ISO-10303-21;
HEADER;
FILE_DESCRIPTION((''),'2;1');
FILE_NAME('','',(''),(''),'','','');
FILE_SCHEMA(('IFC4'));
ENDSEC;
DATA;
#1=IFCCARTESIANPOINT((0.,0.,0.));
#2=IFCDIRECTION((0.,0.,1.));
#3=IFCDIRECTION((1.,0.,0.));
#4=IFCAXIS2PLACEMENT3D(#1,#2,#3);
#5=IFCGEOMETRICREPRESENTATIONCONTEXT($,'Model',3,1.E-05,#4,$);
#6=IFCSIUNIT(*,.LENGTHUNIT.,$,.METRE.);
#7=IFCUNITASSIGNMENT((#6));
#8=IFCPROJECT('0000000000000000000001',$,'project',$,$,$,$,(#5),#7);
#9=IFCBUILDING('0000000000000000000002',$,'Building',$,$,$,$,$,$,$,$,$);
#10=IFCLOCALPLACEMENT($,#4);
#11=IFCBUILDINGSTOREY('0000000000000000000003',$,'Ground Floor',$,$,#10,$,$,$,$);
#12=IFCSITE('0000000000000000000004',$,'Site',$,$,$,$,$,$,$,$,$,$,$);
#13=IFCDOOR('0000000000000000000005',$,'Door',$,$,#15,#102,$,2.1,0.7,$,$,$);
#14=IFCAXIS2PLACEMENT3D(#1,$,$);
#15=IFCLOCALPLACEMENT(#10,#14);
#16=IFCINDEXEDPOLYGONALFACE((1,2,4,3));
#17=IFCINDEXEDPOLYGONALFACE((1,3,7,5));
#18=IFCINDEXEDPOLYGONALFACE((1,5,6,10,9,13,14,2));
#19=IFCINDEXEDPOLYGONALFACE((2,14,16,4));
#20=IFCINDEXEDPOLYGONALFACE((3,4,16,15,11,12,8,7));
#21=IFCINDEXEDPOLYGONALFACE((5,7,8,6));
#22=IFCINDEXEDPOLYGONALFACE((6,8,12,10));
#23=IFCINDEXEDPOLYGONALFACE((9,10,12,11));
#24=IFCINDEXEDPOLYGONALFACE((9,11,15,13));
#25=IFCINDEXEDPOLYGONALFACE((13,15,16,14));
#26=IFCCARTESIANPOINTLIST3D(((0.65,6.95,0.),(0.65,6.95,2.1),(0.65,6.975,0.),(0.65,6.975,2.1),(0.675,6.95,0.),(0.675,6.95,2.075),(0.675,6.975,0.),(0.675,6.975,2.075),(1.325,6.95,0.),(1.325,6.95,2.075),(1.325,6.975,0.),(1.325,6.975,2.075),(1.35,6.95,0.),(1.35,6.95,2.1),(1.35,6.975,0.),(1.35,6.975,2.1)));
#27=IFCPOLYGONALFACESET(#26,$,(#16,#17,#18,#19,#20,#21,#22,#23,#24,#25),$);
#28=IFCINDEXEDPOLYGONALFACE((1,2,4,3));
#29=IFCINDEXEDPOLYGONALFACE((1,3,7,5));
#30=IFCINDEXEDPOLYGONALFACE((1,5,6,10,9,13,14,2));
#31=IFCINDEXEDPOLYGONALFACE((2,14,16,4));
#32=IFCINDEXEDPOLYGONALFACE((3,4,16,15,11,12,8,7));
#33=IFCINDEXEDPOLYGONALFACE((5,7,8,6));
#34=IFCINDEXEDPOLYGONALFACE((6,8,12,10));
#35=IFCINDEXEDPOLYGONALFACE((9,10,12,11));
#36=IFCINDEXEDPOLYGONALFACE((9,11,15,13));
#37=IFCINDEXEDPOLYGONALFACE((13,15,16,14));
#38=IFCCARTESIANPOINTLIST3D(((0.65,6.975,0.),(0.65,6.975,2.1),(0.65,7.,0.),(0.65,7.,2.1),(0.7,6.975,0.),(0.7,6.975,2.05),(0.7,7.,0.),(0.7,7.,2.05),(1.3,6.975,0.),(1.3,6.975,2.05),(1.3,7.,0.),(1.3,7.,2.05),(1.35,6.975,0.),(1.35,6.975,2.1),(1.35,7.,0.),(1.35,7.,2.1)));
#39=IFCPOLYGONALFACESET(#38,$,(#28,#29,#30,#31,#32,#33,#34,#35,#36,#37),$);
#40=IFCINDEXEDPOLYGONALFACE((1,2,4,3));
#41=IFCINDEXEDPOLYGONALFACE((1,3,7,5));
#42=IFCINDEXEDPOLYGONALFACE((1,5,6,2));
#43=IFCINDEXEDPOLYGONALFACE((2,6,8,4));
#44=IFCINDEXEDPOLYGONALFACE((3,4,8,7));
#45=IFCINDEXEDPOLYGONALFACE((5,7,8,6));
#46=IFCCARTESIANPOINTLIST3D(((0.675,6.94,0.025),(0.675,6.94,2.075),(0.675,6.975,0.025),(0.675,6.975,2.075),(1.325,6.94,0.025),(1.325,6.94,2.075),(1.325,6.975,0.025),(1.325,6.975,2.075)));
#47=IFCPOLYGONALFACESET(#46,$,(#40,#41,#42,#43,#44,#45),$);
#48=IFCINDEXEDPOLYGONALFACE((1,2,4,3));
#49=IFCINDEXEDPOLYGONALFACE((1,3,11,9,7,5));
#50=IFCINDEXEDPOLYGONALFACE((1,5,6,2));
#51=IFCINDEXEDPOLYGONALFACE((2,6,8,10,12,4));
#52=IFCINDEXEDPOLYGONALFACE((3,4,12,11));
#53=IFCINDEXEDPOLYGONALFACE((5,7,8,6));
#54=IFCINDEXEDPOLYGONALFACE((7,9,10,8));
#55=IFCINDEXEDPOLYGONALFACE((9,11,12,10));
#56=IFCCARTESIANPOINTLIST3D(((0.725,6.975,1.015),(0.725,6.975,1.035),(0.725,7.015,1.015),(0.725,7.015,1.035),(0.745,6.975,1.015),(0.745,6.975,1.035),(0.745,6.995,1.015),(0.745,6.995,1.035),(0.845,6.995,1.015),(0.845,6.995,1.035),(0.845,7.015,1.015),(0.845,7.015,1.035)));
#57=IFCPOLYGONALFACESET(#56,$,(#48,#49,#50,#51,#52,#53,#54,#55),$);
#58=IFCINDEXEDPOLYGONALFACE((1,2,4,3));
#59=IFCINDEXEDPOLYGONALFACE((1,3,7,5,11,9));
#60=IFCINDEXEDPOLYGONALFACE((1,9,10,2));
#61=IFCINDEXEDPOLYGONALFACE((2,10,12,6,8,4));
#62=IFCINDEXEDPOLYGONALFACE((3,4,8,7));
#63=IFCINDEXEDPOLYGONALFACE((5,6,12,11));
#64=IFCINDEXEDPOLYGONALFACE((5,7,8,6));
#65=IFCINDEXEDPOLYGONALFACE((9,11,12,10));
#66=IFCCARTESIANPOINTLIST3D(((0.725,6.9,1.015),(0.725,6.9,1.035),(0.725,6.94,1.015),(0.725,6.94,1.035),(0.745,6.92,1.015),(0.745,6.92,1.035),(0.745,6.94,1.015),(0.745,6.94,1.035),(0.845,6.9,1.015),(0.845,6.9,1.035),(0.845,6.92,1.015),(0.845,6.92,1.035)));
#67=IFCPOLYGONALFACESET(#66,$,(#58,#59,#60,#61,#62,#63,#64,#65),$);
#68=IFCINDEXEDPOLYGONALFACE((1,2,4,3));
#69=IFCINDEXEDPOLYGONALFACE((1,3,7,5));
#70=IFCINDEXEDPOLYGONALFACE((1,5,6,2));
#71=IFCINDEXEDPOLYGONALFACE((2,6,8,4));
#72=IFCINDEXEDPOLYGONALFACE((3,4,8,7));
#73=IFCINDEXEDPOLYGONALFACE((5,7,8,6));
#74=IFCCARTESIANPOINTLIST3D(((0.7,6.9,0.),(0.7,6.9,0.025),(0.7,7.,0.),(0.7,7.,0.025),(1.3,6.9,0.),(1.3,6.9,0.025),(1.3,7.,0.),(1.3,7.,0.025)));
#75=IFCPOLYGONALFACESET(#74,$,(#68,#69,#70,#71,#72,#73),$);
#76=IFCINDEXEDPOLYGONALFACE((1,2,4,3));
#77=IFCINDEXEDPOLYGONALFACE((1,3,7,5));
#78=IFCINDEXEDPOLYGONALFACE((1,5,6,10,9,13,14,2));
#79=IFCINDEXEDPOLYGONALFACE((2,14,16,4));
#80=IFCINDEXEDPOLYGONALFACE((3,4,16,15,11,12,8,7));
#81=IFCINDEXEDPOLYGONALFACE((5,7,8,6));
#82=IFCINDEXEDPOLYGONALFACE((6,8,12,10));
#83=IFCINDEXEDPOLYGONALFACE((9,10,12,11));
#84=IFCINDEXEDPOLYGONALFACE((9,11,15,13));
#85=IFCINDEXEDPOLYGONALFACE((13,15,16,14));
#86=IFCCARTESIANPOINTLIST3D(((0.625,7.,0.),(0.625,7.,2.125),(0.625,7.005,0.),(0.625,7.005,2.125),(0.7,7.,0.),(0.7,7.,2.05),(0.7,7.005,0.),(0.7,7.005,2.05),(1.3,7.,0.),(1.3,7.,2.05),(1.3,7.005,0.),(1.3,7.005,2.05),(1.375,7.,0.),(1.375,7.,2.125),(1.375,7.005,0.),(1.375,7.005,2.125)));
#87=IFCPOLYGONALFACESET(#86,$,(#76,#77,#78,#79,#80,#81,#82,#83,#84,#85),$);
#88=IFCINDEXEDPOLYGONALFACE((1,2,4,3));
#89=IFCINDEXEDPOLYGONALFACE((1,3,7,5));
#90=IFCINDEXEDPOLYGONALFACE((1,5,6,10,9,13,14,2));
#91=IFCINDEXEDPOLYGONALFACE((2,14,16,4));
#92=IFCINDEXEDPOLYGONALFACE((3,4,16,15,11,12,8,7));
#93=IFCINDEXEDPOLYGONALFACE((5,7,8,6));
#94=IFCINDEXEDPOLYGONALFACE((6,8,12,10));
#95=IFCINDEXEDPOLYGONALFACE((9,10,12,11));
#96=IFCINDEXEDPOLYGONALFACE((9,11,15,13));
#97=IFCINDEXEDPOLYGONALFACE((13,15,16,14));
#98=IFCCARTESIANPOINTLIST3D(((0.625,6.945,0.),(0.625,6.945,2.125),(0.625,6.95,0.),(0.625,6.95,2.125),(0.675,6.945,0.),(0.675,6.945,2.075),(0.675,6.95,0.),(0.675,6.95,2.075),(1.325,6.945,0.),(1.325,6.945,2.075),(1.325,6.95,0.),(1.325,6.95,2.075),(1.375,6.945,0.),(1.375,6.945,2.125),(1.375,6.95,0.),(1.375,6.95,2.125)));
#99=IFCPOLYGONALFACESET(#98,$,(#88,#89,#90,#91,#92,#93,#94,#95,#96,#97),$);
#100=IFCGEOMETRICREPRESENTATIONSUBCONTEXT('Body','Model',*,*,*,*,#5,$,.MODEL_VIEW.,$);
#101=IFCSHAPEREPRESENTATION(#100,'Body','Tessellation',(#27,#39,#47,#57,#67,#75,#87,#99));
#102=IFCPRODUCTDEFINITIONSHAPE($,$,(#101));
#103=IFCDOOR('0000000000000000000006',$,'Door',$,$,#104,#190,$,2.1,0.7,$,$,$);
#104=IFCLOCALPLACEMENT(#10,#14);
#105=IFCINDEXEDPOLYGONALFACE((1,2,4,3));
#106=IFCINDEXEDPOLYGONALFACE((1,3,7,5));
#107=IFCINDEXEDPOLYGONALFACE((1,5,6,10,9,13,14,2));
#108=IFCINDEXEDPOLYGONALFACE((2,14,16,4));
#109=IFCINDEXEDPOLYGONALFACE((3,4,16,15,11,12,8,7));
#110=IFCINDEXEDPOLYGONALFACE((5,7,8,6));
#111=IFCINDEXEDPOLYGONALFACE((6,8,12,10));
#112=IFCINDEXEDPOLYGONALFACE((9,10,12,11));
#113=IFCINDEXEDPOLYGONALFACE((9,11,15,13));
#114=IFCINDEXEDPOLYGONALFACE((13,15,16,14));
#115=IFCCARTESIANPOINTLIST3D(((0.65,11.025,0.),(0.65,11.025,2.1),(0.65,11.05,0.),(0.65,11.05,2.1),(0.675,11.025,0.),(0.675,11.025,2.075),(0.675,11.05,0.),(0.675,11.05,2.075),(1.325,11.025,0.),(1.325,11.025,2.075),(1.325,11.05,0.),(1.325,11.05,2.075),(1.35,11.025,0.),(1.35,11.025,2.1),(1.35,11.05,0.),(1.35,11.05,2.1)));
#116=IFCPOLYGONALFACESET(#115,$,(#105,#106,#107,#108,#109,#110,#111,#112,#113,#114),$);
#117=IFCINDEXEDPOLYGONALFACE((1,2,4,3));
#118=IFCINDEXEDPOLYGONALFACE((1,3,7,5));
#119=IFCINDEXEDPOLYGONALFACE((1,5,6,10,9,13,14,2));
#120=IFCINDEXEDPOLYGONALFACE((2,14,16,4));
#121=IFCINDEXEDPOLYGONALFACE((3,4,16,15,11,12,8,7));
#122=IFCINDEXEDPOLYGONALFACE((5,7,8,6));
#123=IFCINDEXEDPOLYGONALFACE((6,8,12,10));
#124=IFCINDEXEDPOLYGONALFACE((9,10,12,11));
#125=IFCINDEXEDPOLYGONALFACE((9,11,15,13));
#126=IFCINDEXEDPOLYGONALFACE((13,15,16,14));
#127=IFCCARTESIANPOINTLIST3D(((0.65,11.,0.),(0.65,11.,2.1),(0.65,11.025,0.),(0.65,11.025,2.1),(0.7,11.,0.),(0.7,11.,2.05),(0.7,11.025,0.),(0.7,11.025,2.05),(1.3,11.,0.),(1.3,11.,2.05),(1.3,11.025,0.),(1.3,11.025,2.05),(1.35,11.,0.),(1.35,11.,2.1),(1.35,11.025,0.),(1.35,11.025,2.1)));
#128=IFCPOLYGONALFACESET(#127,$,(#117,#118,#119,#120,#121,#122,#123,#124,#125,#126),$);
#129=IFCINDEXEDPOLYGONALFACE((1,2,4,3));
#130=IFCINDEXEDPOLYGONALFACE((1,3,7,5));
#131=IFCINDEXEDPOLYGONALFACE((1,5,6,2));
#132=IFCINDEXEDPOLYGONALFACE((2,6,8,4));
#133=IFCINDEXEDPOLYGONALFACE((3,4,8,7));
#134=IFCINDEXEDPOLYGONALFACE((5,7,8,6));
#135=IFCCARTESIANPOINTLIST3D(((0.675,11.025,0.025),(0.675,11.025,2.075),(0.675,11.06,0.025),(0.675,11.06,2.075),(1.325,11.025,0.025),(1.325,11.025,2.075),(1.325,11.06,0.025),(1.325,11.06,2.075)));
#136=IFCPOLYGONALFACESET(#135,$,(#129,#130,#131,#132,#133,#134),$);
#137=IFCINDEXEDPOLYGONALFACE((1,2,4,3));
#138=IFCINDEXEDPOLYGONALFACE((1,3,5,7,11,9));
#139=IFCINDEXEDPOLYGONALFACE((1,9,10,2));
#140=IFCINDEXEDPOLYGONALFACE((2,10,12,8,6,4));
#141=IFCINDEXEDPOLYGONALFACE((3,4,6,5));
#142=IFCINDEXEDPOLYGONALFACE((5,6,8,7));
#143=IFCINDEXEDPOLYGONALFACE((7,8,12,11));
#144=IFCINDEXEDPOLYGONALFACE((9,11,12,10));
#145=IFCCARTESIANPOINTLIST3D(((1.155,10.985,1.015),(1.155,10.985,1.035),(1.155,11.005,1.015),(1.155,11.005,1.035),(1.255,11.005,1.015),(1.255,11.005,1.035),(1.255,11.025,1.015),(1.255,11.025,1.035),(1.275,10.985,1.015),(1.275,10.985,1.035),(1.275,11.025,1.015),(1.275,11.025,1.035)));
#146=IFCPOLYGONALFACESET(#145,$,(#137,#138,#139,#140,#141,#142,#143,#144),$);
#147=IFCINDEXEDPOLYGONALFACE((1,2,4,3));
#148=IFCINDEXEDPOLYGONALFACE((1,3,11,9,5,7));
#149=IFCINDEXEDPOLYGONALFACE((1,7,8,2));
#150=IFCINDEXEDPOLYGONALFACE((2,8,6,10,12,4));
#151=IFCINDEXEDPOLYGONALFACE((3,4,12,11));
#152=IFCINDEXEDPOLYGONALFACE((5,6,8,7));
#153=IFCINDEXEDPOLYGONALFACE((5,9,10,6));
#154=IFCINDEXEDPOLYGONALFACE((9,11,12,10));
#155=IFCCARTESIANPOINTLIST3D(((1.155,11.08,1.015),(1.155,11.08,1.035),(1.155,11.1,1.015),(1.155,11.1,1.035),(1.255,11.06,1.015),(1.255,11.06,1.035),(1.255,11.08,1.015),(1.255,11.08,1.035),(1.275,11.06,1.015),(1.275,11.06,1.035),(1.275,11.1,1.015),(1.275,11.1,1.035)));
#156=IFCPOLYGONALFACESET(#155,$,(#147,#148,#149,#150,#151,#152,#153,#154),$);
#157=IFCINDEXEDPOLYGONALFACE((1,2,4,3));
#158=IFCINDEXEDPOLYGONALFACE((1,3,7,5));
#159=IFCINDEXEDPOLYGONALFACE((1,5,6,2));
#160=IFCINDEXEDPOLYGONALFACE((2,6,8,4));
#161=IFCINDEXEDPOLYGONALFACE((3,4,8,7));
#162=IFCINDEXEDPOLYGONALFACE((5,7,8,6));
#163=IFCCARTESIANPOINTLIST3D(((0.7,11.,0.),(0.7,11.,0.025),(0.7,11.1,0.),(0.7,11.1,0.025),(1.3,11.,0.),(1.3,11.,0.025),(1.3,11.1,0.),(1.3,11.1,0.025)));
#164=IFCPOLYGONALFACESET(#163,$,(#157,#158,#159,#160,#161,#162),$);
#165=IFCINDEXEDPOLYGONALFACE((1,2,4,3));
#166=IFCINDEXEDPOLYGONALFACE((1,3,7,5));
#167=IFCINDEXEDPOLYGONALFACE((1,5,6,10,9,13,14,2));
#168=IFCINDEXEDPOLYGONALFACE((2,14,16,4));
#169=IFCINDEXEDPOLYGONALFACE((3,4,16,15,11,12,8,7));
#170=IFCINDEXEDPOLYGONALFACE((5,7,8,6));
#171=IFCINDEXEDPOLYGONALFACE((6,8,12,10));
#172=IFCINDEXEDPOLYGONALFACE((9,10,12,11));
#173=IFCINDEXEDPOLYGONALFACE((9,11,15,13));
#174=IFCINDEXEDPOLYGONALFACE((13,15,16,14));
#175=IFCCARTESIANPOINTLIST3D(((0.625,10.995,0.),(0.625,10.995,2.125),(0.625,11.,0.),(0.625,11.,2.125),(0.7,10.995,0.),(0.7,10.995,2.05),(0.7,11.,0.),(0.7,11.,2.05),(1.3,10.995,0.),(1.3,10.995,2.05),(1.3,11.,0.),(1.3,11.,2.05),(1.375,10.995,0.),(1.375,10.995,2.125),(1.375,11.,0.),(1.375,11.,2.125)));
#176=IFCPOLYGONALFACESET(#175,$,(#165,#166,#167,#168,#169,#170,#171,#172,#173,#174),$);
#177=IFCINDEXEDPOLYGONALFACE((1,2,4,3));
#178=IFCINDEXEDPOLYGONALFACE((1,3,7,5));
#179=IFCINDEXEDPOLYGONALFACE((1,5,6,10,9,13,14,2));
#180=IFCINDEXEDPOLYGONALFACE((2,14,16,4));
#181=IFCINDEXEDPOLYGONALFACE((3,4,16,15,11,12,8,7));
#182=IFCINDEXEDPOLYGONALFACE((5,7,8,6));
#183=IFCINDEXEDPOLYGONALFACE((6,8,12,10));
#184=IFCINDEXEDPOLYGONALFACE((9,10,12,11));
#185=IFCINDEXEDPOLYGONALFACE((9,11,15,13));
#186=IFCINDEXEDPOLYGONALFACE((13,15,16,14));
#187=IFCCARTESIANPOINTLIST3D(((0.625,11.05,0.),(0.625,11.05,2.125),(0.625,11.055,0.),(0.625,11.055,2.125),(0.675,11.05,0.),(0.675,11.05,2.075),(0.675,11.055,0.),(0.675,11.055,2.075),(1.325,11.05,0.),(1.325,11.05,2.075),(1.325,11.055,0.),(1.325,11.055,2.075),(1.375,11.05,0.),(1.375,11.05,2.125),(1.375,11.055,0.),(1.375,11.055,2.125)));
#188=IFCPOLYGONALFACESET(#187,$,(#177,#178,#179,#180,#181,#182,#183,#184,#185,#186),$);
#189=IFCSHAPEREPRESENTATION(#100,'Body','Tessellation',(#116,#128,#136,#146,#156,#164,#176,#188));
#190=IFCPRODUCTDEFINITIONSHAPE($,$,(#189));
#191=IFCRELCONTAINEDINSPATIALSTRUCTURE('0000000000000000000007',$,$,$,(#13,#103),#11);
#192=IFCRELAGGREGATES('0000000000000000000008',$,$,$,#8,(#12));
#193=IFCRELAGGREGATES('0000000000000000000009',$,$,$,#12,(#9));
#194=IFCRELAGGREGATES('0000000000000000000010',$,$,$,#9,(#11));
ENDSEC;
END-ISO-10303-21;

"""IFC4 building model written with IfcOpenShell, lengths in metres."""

from ifc_helpers import new_model, si_unit, frame, origin_with_axes, place, context, subcontext, project, spatial, line, indexed_curve, outline, extrude, element, save


model = new_model("IFC4")

# Units and contexts
model_context = context("Model", 3, precision=1e-05, world=origin_with_axes())
body_context = subcontext(model_context, "Body", "Model", "MODEL_VIEW")
ifc_project = project(units=[si_unit("LENGTHUNIT", "METRE")], contexts=[model_context])

# Site, building, storey
site = spatial("IfcSite", under=ifc_project, Name="Site")
building = spatial("IfcBuilding", under=site, Name="Building")
storey_placement = place(None, origin_with_axes())
storey = spatial("IfcBuildingStorey", under=building, at=storey_placement, Name="Ground Floor")

# Doors
door_1_placement = place(storey_placement, frame((1.35, 7.0, 0.0), z_axis=(0.0, 0.0, 1.0), x_axis=(-1.0, 0.0, 0.0)))
element("IfcDoor", 1, at=door_1_placement, inside=storey, Name="Door", OverallHeight=2.1, OverallWidth=0.7, context=body_context, shape_type="SweptSolid", body=[
    extrude(outline(indexed_curve([(0.0, 0.0), (0.0, 2.1), (0.7, 2.1), (0.7, 0.0), (0.675, 0.0), (0.675, 2.075), (0.025, 2.075), (0.025, 0.0)], segments=[line(1, 2, 3, 4, 5, 6, 7, 8, 1)])), frame((0.0, 0.025, 0.0), z_axis=(0.0, -1.0, 0.0), x_axis=(1.0, 0.0, 0.0)), (0.0, 0.0, -1.0), 0.025),
    extrude(outline(indexed_curve([(0.0, 0.0), (0.0, 2.1), (0.7, 2.1), (0.7, 0.0), (0.65, 0.0), (0.65, 2.05), (0.05, 2.05), (0.05, 0.0)], segments=[line(1, 2, 3, 4, 5, 6, 7, 8, 1)])), frame((0.0, 0.0, 0.0), z_axis=(0.0, -1.0, 0.0), x_axis=(1.0, 0.0, 0.0)), (0.0, 0.0, -1.0), 0.025),
    extrude(outline(indexed_curve([(0.0, 0.0), (0.65, 0.0), (0.65, 0.035), (0.0, 0.035)], segments=[line(1, 2, 3, 4, 1)])), frame((0.025, 0.025, 0.025), z_axis=(0.0, 0.0, 1.0), x_axis=(1.0, 0.0, 0.0)), (0.0, 0.0, 1.0), 2.05),
    extrude(outline(indexed_curve([(0.0, 0.0), (0.0, -0.04), (-0.12, -0.04), (-0.12, -0.02), (-0.02, -0.02), (-0.02, 0.0)], segments=[line(1, 2, 3, 4, 5, 6, 1)])), frame((0.625, 0.025, 1.015), z_axis=(0.0, 0.0, 1.0), x_axis=(1.0, 0.0, 0.0)), (0.0, 0.0, 1.0), 0.02),
    extrude(outline(indexed_curve([(0.0, 0.0), (0.0, 0.04), (-0.12, 0.04), (-0.12, 0.02), (-0.02, 0.02), (-0.02, 0.0)], segments=[line(1, 2, 3, 4, 5, 6, 1)])), frame((0.625, 0.06, 1.015), z_axis=(0.0, 0.0, 1.0), x_axis=(1.0, 0.0, 0.0)), (0.0, 0.0, 1.0), 0.02),
    extrude(outline(indexed_curve([(0.0, 0.0), (0.6, 0.0), (0.6, 0.1), (0.0, 0.1)], segments=[line(1, 2, 3, 4, 1)])), frame((0.05, 0.0, 0.0), z_axis=(0.0, 0.0, 1.0), x_axis=(1.0, 0.0, 0.0)), (0.0, 0.0, 1.0), 0.025),
    extrude(outline(indexed_curve([(0.0, 0.0), (0.0, 2.125), (0.75, 2.125), (0.75, 0.0), (0.675, 0.0), (0.675, 2.05), (0.075, 2.05), (0.075, 0.0)], segments=[line(1, 2, 3, 4, 5, 6, 7, 8, 1)])), frame((-0.025, -0.005, 0.0), z_axis=(0.0, -1.0, 0.0), x_axis=(1.0, 0.0, 0.0)), (0.0, 0.0, -1.0), 0.005),
    extrude(outline(indexed_curve([(0.0, 0.0), (0.0, 2.125), (0.75, 2.125), (0.75, 0.0), (0.7, 0.0), (0.7, 2.075), (0.05, 2.075), (0.05, 0.0)], segments=[line(1, 2, 3, 4, 5, 6, 7, 8, 1)])), frame((-0.025, 0.05, 0.0), z_axis=(0.0, -1.0, 0.0), x_axis=(1.0, 0.0, 0.0)), (0.0, 0.0, -1.0), 0.005),
])
door_2_placement = place(storey_placement, frame((0.65, 11.0, 0.0), z_axis=(0.0, 0.0, 1.0), x_axis=(1.0, 0.0, 0.0)))
element("IfcDoor", 2, at=door_2_placement, inside=storey, Name="Door", OverallHeight=2.1, OverallWidth=0.7, context=body_context, shape_type="SweptSolid", body=[
    extrude(outline(indexed_curve([(0.0, 0.0), (0.0, 2.1), (0.7, 2.1), (0.7, 0.0), (0.675, 0.0), (0.675, 2.075), (0.025, 2.075), (0.025, 0.0)], segments=[line(1, 2, 3, 4, 5, 6, 7, 8, 1)])), frame((0.0, 0.025, 0.0), z_axis=(0.0, -1.0, 0.0), x_axis=(1.0, 0.0, 0.0)), (0.0, 0.0, -1.0), 0.025),
    extrude(outline(indexed_curve([(0.0, 0.0), (0.0, 2.1), (0.7, 2.1), (0.7, 0.0), (0.65, 0.0), (0.65, 2.05), (0.05, 2.05), (0.05, 0.0)], segments=[line(1, 2, 3, 4, 5, 6, 7, 8, 1)])), frame((0.0, 0.0, 0.0), z_axis=(0.0, -1.0, 0.0), x_axis=(1.0, 0.0, 0.0)), (0.0, 0.0, -1.0), 0.025),
    extrude(outline(indexed_curve([(0.0, 0.0), (0.65, 0.0), (0.65, 0.035), (0.0, 0.035)], segments=[line(1, 2, 3, 4, 1)])), frame((0.025, 0.025, 0.025), z_axis=(0.0, 0.0, 1.0), x_axis=(1.0, 0.0, 0.0)), (0.0, 0.0, 1.0), 2.05),
    extrude(outline(indexed_curve([(0.0, 0.0), (0.0, -0.04), (-0.12, -0.04), (-0.12, -0.02), (-0.02, -0.02), (-0.02, 0.0)], segments=[line(1, 2, 3, 4, 5, 6, 1)])), frame((0.625, 0.025, 1.015), z_axis=(0.0, 0.0, 1.0), x_axis=(1.0, 0.0, 0.0)), (0.0, 0.0, 1.0), 0.02),
    extrude(outline(indexed_curve([(0.0, 0.0), (0.0, 0.04), (-0.12, 0.04), (-0.12, 0.02), (-0.02, 0.02), (-0.02, 0.0)], segments=[line(1, 2, 3, 4, 5, 6, 1)])), frame((0.625, 0.06, 1.015), z_axis=(0.0, 0.0, 1.0), x_axis=(1.0, 0.0, 0.0)), (0.0, 0.0, 1.0), 0.02),
    extrude(outline(indexed_curve([(0.0, 0.0), (0.6, 0.0), (0.6, 0.1), (0.0, 0.1)], segments=[line(1, 2, 3, 4, 1)])), frame((0.05, 0.0, 0.0), z_axis=(0.0, 0.0, 1.0), x_axis=(1.0, 0.0, 0.0)), (0.0, 0.0, 1.0), 0.025),
    extrude(outline(indexed_curve([(0.0, 0.0), (0.0, 2.125), (0.75, 2.125), (0.75, 0.0), (0.675, 0.0), (0.675, 2.05), (0.075, 2.05), (0.075, 0.0)], segments=[line(1, 2, 3, 4, 5, 6, 7, 8, 1)])), frame((-0.025, -0.005, 0.0), z_axis=(0.0, -1.0, 0.0), x_axis=(1.0, 0.0, 0.0)), (0.0, 0.0, -1.0), 0.005),
    extrude(outline(indexed_curve([(0.0, 0.0), (0.0, 2.125), (0.75, 2.125), (0.75, 0.0), (0.7, 0.0), (0.7, 2.075), (0.05, 2.075), (0.05, 0.0)], segments=[line(1, 2, 3, 4, 5, 6, 7, 8, 1)])), frame((-0.025, 0.05, 0.0), z_axis=(0.0, -1.0, 0.0), x_axis=(1.0, 0.0, 0.0)), (0.0, 0.0, -1.0), 0.005),
])

save(model, "model.ifc")
